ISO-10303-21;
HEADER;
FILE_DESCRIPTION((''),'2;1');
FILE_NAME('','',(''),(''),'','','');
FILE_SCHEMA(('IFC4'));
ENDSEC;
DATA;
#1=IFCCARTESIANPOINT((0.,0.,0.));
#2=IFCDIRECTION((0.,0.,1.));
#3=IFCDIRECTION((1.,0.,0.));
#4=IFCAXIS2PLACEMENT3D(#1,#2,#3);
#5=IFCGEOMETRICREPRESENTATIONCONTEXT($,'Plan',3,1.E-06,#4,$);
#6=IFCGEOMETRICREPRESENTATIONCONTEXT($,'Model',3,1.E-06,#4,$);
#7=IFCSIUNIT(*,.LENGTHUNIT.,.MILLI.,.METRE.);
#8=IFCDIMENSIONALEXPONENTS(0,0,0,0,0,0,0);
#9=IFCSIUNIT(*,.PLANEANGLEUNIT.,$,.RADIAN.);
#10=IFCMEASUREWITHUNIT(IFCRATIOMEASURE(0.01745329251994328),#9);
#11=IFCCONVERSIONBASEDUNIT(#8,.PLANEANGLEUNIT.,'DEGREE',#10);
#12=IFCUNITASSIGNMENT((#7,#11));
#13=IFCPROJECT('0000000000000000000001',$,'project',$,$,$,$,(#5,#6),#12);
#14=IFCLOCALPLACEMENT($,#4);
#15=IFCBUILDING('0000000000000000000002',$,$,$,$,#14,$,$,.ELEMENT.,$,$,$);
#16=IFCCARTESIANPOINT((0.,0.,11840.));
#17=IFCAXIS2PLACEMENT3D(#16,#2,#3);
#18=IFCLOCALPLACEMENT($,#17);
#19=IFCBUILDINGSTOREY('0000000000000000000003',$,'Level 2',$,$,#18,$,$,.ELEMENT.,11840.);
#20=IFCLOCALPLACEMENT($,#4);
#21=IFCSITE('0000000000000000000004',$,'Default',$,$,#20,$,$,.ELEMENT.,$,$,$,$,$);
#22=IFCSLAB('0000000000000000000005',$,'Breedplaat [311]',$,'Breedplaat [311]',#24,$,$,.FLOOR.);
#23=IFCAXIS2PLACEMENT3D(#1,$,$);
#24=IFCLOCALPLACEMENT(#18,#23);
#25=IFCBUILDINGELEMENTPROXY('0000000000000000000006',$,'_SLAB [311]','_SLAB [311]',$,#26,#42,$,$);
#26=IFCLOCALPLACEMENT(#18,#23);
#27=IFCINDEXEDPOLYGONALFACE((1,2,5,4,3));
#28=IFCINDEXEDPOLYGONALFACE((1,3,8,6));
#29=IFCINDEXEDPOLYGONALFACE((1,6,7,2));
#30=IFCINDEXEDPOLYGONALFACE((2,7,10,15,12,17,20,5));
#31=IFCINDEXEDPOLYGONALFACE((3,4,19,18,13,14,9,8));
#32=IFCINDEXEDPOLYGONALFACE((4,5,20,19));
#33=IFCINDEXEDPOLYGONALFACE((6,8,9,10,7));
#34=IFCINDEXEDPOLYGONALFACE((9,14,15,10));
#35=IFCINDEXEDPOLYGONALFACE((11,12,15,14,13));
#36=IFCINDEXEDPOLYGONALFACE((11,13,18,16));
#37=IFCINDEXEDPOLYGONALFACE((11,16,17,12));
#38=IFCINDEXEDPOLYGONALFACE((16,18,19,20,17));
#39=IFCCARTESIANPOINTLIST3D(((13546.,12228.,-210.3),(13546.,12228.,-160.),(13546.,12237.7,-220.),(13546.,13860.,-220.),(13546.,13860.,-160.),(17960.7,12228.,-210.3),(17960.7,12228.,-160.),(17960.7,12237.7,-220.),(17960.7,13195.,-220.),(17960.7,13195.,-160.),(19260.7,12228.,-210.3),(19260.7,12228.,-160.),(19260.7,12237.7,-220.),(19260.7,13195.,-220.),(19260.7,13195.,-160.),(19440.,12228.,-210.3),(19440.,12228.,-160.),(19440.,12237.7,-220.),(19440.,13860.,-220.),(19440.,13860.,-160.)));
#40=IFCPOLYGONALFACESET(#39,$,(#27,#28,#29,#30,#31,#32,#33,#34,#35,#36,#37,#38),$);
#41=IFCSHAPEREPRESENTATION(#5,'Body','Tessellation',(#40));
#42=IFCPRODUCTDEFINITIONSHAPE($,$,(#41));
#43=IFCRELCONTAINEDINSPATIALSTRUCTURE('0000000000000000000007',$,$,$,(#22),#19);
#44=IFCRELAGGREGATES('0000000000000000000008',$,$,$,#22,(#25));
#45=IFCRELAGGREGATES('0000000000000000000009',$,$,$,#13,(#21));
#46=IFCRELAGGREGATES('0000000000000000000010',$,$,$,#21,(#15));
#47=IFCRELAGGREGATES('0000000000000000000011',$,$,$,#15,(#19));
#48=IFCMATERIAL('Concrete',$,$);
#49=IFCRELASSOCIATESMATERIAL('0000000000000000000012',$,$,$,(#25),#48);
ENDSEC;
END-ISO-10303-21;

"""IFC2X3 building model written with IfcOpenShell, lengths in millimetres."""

from ifc_helpers import new_model, entity, si_unit, converted_unit, frame, origin_with_axes, origin_2d_with_axis, place, context, project, spatial, polyline, rectangle, outline, extrude, material, element, aggregate, save


model = new_model("IFC2X3")

# Units and contexts
plan_context = context("Plan", 3, precision=1e-06, world=origin_with_axes())
model_context = context("Model", 3, precision=1e-06, world=origin_with_axes())
ifc_project = project(units=[si_unit("LENGTHUNIT", "METRE", prefix="MILLI"), converted_unit("PLANEANGLEUNIT", "DEGREE", entity("IfcRatioMeasure", 0.01745329251994328), si_unit("PLANEANGLEUNIT", "RADIAN"), dimensions=[0, 0, 0, 0, 0, 0, 0])], contexts=[plan_context, model_context])

# Site, building, storey
site_placement = place(None, origin_with_axes())
site = spatial("IfcSite", under=ifc_project, at=site_placement, Name="Default", CompositionType="ELEMENT")
building_placement = place(None, origin_with_axes())
building = spatial("IfcBuilding", under=site, at=building_placement, CompositionType="ELEMENT")
storey_placement = place(None, frame((0.0, 0.0, 11840.0), z_axis=(0.0, 0.0, 1.0), x_axis=(1.0, 0.0, 0.0)))
storey = spatial("IfcBuildingStorey", under=building, at=storey_placement, Name="Level 2", CompositionType="ELEMENT", Elevation=11840.0)

# Slab, building element proxy, openings
slab_1_placement = place(None, frame((13546.0, 12228.0, 11620.0), z_axis=(0.0, 0.0, 1.0), x_axis=(1.0, 0.0, 0.0)))
slab_1 = element("IfcSlab", 1, at=slab_1_placement, inside=storey, Name="Breedplaat [311]", ObjectType="Breedplaat [311]", PredefinedType="FLOOR")
ifc_material_1 = material(Name="Concrete")
proxy_1_placement = place(slab_1_placement, origin_with_axes())
proxy_1 = element("IfcBuildingElementProxy", 2, at=proxy_1_placement, material=ifc_material_1, Name="_SLAB [311]", Description="_SLAB [311]", context=plan_context, shape_type="SweptSolid", body=[
    extrude(outline(polyline([(0.0, 0.0), (5894.0, 0.0), (5894.0, 1632.0), (0.0, 1632.0), (0.0, 0.0)])), origin_with_axes(), (0.0, 0.0, 1.0), 60.0),
])
opening_1_placement = place(slab_1_placement, frame((4414.7, 0.0, 0.0), z_axis=(0.0, 0.0, 1.0), x_axis=(1.0, 0.0, 0.0)))
element("IfcOpeningElement", 3, at=opening_1_placement, cuts=proxy_1, ObjectType="Opening", context=plan_context, shape_type="SolidModel", body=[
    extrude(rectangle(XDim=1300.0, YDim=967.0, at=origin_2d_with_axis()), frame((650.0, 483.5, 0.0), z_axis=(0.0, 0.0, 1.0), x_axis=(1.0, 0.0, 0.0)), (0.0, 0.0, 1.0), 60.0),
])
opening_2_placement = place(None, frame((13546.0, 12228.0, 11620.0), z_axis=(0.0, 0.0, 1.0), x_axis=(1.0, 0.0, 0.0)))
element("IfcOpeningElement", 4, at=opening_2_placement, cuts=proxy_1, ObjectType="Opening", context=plan_context, shape_type="SweptSolid", body=[
    extrude(outline(polyline([(-0.1, -0.1), (-0.1, 10.0), (10.0, -0.1), (-0.1, -0.1)])), frame((-1.2, -0.1, -0.1), z_axis=(1.0, 0.0, 0.0), x_axis=(0.0, 1.0, 0.0)), (0.0, 0.0, 1.0), 5896.2),
])
aggregate(slab_1, [proxy_1])

save(model, "model.ifc")
